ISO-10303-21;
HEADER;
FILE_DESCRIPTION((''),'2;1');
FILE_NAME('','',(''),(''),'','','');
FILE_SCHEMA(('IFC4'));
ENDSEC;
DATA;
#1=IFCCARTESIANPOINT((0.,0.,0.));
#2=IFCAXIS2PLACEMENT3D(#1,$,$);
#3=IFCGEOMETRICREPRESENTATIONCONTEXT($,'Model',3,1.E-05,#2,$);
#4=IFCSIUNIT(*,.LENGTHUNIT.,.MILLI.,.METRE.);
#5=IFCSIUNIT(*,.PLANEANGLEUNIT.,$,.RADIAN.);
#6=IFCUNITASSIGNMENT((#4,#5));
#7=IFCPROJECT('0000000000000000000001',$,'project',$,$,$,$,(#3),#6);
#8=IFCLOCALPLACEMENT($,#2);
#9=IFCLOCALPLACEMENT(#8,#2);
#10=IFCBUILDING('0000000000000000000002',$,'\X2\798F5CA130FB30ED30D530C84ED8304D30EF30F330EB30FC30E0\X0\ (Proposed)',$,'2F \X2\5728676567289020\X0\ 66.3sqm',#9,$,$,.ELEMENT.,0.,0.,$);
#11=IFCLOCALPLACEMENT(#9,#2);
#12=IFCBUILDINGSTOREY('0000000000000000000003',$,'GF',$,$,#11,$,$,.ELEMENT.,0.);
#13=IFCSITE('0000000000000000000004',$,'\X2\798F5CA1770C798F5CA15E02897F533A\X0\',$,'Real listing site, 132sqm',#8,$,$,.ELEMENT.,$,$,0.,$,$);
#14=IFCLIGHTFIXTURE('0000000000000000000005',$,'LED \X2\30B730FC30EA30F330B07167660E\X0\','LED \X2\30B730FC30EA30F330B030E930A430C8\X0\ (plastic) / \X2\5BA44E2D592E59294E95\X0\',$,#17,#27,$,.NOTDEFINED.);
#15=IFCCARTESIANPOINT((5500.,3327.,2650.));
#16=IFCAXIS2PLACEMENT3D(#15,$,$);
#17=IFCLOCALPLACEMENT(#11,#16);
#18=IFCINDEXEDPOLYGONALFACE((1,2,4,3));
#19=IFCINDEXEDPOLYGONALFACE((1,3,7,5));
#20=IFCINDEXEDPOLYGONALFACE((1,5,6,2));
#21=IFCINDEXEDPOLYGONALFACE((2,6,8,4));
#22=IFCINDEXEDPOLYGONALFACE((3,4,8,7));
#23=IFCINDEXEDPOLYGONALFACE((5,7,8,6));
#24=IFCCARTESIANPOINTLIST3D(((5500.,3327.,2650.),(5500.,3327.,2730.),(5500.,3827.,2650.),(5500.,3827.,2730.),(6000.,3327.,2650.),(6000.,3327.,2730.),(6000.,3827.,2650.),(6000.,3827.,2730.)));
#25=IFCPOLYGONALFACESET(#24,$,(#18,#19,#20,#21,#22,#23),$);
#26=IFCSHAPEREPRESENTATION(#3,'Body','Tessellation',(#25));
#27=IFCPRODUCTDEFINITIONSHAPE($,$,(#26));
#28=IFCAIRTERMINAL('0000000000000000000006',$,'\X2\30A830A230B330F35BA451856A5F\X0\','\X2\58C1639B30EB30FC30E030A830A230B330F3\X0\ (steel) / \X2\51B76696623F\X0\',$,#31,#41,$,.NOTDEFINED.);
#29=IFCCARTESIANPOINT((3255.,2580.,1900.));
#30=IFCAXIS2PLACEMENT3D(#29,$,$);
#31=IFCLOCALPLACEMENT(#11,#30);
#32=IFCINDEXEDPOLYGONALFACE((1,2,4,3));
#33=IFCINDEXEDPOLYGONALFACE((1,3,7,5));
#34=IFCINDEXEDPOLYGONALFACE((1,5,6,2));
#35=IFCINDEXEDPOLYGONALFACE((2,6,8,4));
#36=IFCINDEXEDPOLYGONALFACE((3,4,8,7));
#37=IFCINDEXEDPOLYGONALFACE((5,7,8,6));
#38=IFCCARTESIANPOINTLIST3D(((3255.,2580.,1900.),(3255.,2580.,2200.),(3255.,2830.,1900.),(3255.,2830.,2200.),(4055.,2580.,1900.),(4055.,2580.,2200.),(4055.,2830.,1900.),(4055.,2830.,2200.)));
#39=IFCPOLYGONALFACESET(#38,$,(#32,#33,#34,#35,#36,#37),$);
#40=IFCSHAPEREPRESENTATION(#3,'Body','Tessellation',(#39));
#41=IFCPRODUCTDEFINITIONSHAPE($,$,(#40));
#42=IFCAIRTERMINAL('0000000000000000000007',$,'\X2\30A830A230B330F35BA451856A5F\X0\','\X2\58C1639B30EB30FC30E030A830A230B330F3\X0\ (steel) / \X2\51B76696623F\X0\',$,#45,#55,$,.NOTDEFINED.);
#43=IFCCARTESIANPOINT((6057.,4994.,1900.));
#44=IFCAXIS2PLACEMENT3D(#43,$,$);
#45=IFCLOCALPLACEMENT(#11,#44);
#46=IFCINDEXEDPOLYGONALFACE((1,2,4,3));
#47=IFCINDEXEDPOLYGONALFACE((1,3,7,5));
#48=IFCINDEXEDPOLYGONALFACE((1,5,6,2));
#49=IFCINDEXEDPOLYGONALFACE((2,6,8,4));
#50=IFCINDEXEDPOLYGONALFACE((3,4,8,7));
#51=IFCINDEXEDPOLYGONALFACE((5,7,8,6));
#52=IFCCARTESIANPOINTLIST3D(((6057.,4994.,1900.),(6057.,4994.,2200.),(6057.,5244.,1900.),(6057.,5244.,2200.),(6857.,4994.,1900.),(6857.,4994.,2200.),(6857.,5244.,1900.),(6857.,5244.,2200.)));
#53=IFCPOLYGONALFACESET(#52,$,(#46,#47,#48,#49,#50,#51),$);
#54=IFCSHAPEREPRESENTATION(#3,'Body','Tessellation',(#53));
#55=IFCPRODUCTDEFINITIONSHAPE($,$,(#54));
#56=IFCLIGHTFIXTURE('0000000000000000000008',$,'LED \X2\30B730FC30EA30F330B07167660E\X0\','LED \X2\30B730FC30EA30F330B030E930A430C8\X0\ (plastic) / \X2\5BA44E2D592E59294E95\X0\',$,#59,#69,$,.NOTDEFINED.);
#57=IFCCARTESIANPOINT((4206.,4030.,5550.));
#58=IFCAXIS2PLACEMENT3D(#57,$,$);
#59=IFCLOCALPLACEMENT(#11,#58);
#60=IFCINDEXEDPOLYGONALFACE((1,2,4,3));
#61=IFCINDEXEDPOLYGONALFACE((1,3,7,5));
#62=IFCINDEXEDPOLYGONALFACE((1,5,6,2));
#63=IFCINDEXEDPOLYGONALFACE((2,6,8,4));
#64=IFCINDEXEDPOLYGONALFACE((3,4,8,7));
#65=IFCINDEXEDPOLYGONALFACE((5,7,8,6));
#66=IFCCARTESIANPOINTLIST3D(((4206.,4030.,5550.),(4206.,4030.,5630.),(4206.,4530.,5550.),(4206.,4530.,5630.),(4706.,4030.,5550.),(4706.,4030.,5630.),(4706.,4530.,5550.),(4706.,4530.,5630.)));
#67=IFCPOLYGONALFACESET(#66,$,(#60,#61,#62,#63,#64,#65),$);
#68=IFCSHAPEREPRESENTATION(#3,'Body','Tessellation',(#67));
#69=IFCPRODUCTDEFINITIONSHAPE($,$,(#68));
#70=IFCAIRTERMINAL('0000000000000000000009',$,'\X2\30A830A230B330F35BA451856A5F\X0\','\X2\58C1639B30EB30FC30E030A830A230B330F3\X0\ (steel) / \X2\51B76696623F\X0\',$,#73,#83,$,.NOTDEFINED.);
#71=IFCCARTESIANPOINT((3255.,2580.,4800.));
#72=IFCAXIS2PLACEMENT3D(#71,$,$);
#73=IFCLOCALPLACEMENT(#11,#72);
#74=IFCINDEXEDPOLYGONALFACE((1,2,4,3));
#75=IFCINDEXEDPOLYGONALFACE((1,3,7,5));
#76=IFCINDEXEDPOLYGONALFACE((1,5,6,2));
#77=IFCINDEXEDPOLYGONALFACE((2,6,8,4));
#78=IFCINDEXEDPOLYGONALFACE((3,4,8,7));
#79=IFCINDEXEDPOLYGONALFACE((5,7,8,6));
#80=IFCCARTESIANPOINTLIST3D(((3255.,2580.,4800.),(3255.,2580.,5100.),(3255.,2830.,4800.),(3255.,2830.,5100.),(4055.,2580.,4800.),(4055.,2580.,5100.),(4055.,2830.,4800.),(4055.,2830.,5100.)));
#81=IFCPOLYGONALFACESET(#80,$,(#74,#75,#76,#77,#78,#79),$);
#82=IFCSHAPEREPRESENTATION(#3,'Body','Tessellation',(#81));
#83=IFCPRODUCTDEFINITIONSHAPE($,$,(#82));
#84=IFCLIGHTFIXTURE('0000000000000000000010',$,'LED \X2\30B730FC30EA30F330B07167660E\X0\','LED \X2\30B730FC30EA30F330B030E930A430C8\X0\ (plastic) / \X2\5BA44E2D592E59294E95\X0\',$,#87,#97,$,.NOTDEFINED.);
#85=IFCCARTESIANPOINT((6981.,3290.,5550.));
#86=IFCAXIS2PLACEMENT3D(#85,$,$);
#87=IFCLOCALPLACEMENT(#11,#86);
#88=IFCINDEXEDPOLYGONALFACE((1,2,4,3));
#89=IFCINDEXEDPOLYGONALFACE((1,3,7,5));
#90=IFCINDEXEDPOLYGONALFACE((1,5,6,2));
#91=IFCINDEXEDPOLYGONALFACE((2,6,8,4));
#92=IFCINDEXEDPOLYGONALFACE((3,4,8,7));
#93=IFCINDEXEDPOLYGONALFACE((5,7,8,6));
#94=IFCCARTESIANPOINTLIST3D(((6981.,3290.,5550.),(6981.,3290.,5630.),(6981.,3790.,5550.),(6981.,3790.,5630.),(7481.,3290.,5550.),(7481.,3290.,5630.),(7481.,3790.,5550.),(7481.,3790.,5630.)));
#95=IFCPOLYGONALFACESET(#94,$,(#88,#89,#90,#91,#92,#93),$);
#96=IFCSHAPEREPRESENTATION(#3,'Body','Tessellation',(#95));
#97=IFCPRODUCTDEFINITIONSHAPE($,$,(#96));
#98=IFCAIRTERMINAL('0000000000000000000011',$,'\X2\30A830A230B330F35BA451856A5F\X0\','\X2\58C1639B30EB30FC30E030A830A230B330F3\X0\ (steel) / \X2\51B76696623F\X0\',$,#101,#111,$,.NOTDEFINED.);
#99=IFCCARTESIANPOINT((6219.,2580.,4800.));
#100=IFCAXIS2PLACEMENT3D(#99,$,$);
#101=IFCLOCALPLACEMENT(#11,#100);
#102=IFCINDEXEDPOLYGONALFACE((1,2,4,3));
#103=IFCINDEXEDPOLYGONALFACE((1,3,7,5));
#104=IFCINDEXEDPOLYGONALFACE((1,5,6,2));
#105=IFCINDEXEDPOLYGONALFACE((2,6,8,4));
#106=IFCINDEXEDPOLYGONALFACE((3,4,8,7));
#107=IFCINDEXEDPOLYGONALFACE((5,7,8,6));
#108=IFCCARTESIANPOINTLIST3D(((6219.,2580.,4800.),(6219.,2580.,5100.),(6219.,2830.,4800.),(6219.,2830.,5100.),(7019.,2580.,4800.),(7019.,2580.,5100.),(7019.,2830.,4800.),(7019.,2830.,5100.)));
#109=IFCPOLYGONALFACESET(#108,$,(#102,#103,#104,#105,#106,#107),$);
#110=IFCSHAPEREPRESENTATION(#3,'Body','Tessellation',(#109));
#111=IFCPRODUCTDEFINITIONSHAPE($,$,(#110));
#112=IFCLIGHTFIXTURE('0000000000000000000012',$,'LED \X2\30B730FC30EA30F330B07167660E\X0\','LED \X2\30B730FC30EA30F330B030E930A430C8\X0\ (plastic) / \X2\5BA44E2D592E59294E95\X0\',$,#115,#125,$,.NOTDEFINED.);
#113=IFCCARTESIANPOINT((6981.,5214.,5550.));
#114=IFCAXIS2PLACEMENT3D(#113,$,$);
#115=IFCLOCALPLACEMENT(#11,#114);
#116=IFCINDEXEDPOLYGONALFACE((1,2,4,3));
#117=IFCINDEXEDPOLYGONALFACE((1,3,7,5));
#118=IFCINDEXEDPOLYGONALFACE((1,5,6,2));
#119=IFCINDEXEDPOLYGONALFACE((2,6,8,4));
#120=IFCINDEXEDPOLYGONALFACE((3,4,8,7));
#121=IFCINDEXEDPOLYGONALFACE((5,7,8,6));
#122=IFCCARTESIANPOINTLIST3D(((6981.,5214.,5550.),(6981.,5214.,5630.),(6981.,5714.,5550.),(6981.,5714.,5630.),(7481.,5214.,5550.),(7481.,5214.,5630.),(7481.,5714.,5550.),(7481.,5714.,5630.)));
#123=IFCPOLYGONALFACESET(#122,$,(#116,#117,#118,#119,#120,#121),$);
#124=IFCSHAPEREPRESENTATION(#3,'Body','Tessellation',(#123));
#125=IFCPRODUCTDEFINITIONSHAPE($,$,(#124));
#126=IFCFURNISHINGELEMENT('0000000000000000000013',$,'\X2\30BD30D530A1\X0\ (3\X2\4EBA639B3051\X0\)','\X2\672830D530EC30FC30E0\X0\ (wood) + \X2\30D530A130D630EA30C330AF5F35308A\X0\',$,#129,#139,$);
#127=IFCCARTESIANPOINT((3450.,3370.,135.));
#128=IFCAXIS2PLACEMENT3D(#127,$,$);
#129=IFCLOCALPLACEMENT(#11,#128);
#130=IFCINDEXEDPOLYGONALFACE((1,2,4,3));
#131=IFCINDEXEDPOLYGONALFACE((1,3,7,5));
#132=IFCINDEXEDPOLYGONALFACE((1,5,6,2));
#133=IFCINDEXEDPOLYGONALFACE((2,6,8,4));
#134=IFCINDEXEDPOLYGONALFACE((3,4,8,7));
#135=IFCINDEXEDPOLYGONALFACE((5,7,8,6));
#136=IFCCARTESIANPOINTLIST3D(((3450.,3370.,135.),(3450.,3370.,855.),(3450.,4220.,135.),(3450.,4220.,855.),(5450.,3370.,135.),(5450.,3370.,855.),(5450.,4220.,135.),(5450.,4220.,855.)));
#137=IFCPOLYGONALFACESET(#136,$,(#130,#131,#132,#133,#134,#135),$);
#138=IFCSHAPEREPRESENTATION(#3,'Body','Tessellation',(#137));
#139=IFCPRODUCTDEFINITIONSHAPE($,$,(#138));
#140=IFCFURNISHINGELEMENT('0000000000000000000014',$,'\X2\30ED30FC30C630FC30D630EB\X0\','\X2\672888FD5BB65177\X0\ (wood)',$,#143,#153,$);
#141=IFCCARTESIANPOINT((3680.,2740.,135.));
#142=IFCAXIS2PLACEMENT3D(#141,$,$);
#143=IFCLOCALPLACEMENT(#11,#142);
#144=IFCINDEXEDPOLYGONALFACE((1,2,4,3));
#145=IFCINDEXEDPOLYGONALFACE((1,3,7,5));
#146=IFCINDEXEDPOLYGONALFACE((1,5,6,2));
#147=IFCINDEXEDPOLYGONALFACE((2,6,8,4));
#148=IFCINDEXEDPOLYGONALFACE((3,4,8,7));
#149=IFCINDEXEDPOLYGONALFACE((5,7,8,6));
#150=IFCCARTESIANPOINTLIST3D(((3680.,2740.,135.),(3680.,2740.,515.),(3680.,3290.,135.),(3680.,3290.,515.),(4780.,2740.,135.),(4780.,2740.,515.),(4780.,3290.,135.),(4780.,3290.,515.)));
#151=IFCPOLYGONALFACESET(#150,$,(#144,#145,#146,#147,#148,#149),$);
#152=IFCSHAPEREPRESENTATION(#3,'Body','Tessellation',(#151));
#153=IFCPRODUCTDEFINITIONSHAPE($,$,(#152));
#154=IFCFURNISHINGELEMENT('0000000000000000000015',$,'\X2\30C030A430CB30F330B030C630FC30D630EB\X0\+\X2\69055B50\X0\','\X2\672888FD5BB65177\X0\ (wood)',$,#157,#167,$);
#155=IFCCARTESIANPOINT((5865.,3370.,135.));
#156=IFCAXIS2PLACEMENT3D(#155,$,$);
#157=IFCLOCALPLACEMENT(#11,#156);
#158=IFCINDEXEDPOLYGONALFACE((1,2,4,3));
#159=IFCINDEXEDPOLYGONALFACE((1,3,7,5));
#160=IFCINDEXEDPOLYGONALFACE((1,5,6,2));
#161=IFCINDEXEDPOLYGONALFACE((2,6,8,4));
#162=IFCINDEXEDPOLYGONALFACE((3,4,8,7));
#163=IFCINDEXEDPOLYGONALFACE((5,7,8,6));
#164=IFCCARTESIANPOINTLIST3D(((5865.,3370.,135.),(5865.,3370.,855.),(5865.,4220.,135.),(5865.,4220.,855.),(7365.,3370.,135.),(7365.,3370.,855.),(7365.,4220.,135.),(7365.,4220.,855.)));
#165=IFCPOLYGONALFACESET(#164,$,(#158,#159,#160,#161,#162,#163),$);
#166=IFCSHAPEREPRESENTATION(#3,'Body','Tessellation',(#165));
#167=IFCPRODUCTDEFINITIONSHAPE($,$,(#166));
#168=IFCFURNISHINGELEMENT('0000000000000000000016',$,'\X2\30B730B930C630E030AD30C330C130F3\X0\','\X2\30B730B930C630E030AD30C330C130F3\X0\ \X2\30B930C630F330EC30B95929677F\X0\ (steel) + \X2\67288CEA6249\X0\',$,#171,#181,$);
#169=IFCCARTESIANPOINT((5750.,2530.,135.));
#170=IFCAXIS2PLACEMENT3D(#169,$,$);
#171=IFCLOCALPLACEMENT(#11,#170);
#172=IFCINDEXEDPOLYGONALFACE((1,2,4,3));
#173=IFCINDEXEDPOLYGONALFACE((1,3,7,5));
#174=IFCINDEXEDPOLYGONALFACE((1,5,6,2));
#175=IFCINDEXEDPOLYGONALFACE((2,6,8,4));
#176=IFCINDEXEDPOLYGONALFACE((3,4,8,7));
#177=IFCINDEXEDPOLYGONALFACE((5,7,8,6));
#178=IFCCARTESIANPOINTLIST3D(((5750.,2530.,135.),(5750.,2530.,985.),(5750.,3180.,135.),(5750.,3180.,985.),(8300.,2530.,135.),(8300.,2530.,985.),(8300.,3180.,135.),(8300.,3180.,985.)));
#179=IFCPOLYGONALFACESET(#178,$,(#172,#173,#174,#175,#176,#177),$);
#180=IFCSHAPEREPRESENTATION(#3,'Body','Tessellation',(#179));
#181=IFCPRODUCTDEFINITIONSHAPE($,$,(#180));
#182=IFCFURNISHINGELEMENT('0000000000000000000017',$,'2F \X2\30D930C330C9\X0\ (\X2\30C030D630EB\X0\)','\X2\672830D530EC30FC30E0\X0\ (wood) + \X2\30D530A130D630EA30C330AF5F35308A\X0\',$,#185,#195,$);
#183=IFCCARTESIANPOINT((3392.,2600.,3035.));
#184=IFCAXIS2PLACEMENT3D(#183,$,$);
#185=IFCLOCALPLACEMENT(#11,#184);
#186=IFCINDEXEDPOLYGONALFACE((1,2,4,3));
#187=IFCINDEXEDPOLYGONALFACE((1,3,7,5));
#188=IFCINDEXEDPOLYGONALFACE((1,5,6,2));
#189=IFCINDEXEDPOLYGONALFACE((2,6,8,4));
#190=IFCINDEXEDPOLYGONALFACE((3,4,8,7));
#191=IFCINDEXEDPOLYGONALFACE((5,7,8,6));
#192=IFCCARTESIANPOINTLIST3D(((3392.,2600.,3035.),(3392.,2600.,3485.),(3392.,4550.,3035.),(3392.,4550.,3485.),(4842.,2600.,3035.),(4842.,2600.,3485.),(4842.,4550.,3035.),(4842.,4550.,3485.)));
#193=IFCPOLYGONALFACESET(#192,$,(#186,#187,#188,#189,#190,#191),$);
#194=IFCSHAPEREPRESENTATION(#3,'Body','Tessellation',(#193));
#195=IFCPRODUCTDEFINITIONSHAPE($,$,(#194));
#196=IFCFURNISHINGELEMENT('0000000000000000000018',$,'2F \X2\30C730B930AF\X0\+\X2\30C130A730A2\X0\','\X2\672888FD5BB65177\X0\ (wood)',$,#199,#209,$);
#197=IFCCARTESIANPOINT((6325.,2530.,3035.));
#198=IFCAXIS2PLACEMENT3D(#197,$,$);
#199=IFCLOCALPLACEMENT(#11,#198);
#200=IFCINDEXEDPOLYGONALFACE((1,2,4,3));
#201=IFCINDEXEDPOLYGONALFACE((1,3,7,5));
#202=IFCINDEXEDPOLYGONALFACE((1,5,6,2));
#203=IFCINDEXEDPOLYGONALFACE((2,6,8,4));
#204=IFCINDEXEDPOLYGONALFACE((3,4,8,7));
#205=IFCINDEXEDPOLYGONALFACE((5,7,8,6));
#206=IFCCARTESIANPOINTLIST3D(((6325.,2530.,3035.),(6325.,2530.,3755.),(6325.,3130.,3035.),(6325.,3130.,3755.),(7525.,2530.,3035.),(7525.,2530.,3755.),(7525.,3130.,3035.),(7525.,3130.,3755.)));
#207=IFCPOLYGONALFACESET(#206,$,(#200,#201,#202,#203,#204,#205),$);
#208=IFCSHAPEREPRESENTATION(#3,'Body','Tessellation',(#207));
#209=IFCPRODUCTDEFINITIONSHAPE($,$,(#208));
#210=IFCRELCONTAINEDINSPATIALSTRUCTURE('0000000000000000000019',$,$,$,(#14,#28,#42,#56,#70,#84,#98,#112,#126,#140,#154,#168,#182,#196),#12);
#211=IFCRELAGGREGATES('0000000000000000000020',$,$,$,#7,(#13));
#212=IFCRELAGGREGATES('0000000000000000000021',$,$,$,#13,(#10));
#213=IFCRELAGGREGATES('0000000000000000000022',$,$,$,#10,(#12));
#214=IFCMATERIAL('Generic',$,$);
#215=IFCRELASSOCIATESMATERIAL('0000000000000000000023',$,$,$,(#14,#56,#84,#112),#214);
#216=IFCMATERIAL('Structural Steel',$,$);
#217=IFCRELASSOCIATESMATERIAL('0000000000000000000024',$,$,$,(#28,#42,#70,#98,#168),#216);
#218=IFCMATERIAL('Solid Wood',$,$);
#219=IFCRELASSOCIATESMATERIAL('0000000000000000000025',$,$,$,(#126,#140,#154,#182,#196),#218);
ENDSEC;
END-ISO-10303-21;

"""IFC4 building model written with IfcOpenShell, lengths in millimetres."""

from ifc_helpers import new_model, si_unit, frame, frame_2d, origin, place, context, project, spatial, rectangle, extrude, material, element, save


model = new_model("IFC4")

# Units and contexts
model_context = context("Model", 3, precision=1e-05, world=origin())
ifc_project = project(units=[si_unit("LENGTHUNIT", "METRE", prefix="MILLI"), si_unit("PLANEANGLEUNIT", "RADIAN")], contexts=[model_context])

# Site, building, storey
site_placement = place(None, origin())
site = spatial("IfcSite", under=ifc_project, at=site_placement, Name="福岡県福岡市西区", ObjectType="Real listing site, 132sqm", CompositionType="ELEMENT", RefElevation=0.0)
building_placement = place(site_placement, origin())
building = spatial("IfcBuilding", under=site, at=building_placement, Name="福岡・ロフト付きワンルーム (Proposed)", ObjectType="2F 在来木造 66.3sqm", CompositionType="ELEMENT", ElevationOfRefHeight=0.0, ElevationOfTerrain=0.0)
storey_placement = place(building_placement, origin())
storey = spatial("IfcBuildingStorey", under=building, at=storey_placement, Name="GF", CompositionType="ELEMENT", Elevation=0.0)

# Shared definitions
ifc_material_1 = material(Name="Solid Wood")

# Shared definitions
ifc_material_2 = material(Name="Structural Steel")

# Shared definitions
ifc_material_3 = material(Name="Generic")

# Light fixture
light_fixture_1_placement = place(storey_placement, frame((5500.0, 3327.0, 2650.0)))
element("IfcLightFixture", 1, at=light_fixture_1_placement, inside=storey, material=ifc_material_3, Name="LED シーリング照明", Description="LED シーリングライト (plastic) / 室中央天井", PredefinedType="NOTDEFINED", context=model_context, shape_type="SweptSolid", body=[
    extrude(rectangle(XDim=500.0, YDim=500.0, at=frame_2d((250.0, 250.0))), frame((5500.0, 3327.0, 2650.0)), (0.0, 0.0, 1.0), 80.0),
])

# Air terminals
air_terminal_1_placement = place(storey_placement, frame((3255.0, 2580.0, 1900.0)))
element("IfcAirTerminal", 2, at=air_terminal_1_placement, inside=storey, material=ifc_material_2, Name="エアコン室内機", Description="壁掛ルームエアコン (steel) / 冷暖房", PredefinedType="NOTDEFINED", context=model_context, shape_type="SweptSolid", body=[
    extrude(rectangle(XDim=800.0, YDim=250.0, at=frame_2d((400.0, 125.0))), frame((3255.0, 2580.0, 1900.0)), (0.0, 0.0, 1.0), 300.0),
])
air_terminal_2_placement = place(storey_placement, frame((6057.0, 4994.0, 1900.0)))
element("IfcAirTerminal", 3, at=air_terminal_2_placement, inside=storey, material=ifc_material_2, Name="エアコン室内機", Description="壁掛ルームエアコン (steel) / 冷暖房", PredefinedType="NOTDEFINED", context=model_context, shape_type="SweptSolid", body=[
    extrude(rectangle(XDim=800.0, YDim=250.0, at=frame_2d((400.0, 125.0))), frame((6057.0, 4994.0, 1900.0)), (0.0, 0.0, 1.0), 300.0),
])

# Light fixture
light_fixture_2_placement = place(storey_placement, frame((4206.0, 4030.0, 5550.0)))
element("IfcLightFixture", 4, at=light_fixture_2_placement, inside=storey, material=ifc_material_3, Name="LED シーリング照明", Description="LED シーリングライト (plastic) / 室中央天井", PredefinedType="NOTDEFINED", context=model_context, shape_type="SweptSolid", body=[
    extrude(rectangle(XDim=500.0, YDim=500.0, at=frame_2d((250.0, 250.0))), frame((4206.0, 4030.0, 5550.0)), (0.0, 0.0, 1.0), 80.0),
])

# Air terminal
air_terminal_3_placement = place(storey_placement, frame((3255.0, 2580.0, 4800.0)))
element("IfcAirTerminal", 5, at=air_terminal_3_placement, inside=storey, material=ifc_material_2, Name="エアコン室内機", Description="壁掛ルームエアコン (steel) / 冷暖房", PredefinedType="NOTDEFINED", context=model_context, shape_type="SweptSolid", body=[
    extrude(rectangle(XDim=800.0, YDim=250.0, at=frame_2d((400.0, 125.0))), frame((3255.0, 2580.0, 4800.0)), (0.0, 0.0, 1.0), 300.0),
])

# Light fixture
light_fixture_3_placement = place(storey_placement, frame((6981.0, 3290.0, 5550.0)))
element("IfcLightFixture", 6, at=light_fixture_3_placement, inside=storey, material=ifc_material_3, Name="LED シーリング照明", Description="LED シーリングライト (plastic) / 室中央天井", PredefinedType="NOTDEFINED", context=model_context, shape_type="SweptSolid", body=[
    extrude(rectangle(XDim=500.0, YDim=500.0, at=frame_2d((250.0, 250.0))), frame((6981.0, 3290.0, 5550.0)), (0.0, 0.0, 1.0), 80.0),
])

# Air terminal
air_terminal_4_placement = place(storey_placement, frame((6219.0, 2580.0, 4800.0)))
element("IfcAirTerminal", 7, at=air_terminal_4_placement, inside=storey, material=ifc_material_2, Name="エアコン室内機", Description="壁掛ルームエアコン (steel) / 冷暖房", PredefinedType="NOTDEFINED", context=model_context, shape_type="SweptSolid", body=[
    extrude(rectangle(XDim=800.0, YDim=250.0, at=frame_2d((400.0, 125.0))), frame((6219.0, 2580.0, 4800.0)), (0.0, 0.0, 1.0), 300.0),
])

# Light fixture
light_fixture_4_placement = place(storey_placement, frame((6981.0, 5214.0, 5550.0)))
element("IfcLightFixture", 8, at=light_fixture_4_placement, inside=storey, material=ifc_material_3, Name="LED シーリング照明", Description="LED シーリングライト (plastic) / 室中央天井", PredefinedType="NOTDEFINED", context=model_context, shape_type="SweptSolid", body=[
    extrude(rectangle(XDim=500.0, YDim=500.0, at=frame_2d((250.0, 250.0))), frame((6981.0, 5214.0, 5550.0)), (0.0, 0.0, 1.0), 80.0),
])

# Furnishing elements
furnishing_1_placement = place(storey_placement, frame((3450.0, 3370.0, 135.0)))
element("IfcFurnishingElement", 9, at=furnishing_1_placement, inside=storey, material=ifc_material_1, Name="ソファ (3人掛け)", Description="木フレーム (wood) + ファブリック張り", context=model_context, shape_type="SweptSolid", body=[
    extrude(rectangle(XDim=2000.0, YDim=850.0, at=frame_2d((1000.0, 425.0))), frame((3450.0, 3370.0, 135.0)), (0.0, 0.0, 1.0), 720.0),
])
furnishing_2_placement = place(storey_placement, frame((3680.0, 2740.0, 135.0)))
element("IfcFurnishingElement", 10, at=furnishing_2_placement, inside=storey, material=ifc_material_1, Name="ローテーブル", Description="木製家具 (wood)", context=model_context, shape_type="SweptSolid", body=[
    extrude(rectangle(XDim=1100.0, YDim=550.0, at=frame_2d((550.0, 275.0))), frame((3680.0, 2740.0, 135.0)), (0.0, 0.0, 1.0), 380.0),
])
furnishing_3_placement = place(storey_placement, frame((5865.0, 3370.0, 135.0)))
element("IfcFurnishingElement", 11, at=furnishing_3_placement, inside=storey, material=ifc_material_1, Name="ダイニングテーブル+椅子", Description="木製家具 (wood)", context=model_context, shape_type="SweptSolid", body=[
    extrude(rectangle(XDim=1500.0, YDim=850.0, at=frame_2d((750.0, 425.0))), frame((5865.0, 3370.0, 135.0)), (0.0, 0.0, 1.0), 720.0),
])
furnishing_4_placement = place(storey_placement, frame((5750.0, 2530.0, 135.0)))
element("IfcFurnishingElement", 12, at=furnishing_4_placement, inside=storey, material=ifc_material_2, Name="システムキッチン", Description="システムキッチン ステンレス天板 (steel) + 木質扉", context=model_context, shape_type="SweptSolid", body=[
    extrude(rectangle(XDim=2550.0, YDim=650.0, at=frame_2d((1275.0, 325.0))), frame((5750.0, 2530.0, 135.0)), (0.0, 0.0, 1.0), 850.0),
])
furnishing_5_placement = place(storey_placement, frame((3392.0, 2600.0, 3035.0)))
element("IfcFurnishingElement", 13, at=furnishing_5_placement, inside=storey, material=ifc_material_1, Name="2F ベッド (ダブル)", Description="木フレーム (wood) + ファブリック張り", context=model_context, shape_type="SweptSolid", body=[
    extrude(rectangle(XDim=1450.0, YDim=1950.0, at=frame_2d((725.0, 975.0))), frame((3392.0, 2600.0, 3035.0)), (0.0, 0.0, 1.0), 450.0),
])
furnishing_6_placement = place(storey_placement, frame((6325.0, 2530.0, 3035.0)))
element("IfcFurnishingElement", 14, at=furnishing_6_placement, inside=storey, material=ifc_material_1, Name="2F デスク+チェア", Description="木製家具 (wood)", context=model_context, shape_type="SweptSolid", body=[
    extrude(rectangle(XDim=1200.0, YDim=600.0, at=frame_2d((600.0, 300.0))), frame((6325.0, 2530.0, 3035.0)), (0.0, 0.0, 1.0), 720.0),
])

save(model, "model.ifc")
